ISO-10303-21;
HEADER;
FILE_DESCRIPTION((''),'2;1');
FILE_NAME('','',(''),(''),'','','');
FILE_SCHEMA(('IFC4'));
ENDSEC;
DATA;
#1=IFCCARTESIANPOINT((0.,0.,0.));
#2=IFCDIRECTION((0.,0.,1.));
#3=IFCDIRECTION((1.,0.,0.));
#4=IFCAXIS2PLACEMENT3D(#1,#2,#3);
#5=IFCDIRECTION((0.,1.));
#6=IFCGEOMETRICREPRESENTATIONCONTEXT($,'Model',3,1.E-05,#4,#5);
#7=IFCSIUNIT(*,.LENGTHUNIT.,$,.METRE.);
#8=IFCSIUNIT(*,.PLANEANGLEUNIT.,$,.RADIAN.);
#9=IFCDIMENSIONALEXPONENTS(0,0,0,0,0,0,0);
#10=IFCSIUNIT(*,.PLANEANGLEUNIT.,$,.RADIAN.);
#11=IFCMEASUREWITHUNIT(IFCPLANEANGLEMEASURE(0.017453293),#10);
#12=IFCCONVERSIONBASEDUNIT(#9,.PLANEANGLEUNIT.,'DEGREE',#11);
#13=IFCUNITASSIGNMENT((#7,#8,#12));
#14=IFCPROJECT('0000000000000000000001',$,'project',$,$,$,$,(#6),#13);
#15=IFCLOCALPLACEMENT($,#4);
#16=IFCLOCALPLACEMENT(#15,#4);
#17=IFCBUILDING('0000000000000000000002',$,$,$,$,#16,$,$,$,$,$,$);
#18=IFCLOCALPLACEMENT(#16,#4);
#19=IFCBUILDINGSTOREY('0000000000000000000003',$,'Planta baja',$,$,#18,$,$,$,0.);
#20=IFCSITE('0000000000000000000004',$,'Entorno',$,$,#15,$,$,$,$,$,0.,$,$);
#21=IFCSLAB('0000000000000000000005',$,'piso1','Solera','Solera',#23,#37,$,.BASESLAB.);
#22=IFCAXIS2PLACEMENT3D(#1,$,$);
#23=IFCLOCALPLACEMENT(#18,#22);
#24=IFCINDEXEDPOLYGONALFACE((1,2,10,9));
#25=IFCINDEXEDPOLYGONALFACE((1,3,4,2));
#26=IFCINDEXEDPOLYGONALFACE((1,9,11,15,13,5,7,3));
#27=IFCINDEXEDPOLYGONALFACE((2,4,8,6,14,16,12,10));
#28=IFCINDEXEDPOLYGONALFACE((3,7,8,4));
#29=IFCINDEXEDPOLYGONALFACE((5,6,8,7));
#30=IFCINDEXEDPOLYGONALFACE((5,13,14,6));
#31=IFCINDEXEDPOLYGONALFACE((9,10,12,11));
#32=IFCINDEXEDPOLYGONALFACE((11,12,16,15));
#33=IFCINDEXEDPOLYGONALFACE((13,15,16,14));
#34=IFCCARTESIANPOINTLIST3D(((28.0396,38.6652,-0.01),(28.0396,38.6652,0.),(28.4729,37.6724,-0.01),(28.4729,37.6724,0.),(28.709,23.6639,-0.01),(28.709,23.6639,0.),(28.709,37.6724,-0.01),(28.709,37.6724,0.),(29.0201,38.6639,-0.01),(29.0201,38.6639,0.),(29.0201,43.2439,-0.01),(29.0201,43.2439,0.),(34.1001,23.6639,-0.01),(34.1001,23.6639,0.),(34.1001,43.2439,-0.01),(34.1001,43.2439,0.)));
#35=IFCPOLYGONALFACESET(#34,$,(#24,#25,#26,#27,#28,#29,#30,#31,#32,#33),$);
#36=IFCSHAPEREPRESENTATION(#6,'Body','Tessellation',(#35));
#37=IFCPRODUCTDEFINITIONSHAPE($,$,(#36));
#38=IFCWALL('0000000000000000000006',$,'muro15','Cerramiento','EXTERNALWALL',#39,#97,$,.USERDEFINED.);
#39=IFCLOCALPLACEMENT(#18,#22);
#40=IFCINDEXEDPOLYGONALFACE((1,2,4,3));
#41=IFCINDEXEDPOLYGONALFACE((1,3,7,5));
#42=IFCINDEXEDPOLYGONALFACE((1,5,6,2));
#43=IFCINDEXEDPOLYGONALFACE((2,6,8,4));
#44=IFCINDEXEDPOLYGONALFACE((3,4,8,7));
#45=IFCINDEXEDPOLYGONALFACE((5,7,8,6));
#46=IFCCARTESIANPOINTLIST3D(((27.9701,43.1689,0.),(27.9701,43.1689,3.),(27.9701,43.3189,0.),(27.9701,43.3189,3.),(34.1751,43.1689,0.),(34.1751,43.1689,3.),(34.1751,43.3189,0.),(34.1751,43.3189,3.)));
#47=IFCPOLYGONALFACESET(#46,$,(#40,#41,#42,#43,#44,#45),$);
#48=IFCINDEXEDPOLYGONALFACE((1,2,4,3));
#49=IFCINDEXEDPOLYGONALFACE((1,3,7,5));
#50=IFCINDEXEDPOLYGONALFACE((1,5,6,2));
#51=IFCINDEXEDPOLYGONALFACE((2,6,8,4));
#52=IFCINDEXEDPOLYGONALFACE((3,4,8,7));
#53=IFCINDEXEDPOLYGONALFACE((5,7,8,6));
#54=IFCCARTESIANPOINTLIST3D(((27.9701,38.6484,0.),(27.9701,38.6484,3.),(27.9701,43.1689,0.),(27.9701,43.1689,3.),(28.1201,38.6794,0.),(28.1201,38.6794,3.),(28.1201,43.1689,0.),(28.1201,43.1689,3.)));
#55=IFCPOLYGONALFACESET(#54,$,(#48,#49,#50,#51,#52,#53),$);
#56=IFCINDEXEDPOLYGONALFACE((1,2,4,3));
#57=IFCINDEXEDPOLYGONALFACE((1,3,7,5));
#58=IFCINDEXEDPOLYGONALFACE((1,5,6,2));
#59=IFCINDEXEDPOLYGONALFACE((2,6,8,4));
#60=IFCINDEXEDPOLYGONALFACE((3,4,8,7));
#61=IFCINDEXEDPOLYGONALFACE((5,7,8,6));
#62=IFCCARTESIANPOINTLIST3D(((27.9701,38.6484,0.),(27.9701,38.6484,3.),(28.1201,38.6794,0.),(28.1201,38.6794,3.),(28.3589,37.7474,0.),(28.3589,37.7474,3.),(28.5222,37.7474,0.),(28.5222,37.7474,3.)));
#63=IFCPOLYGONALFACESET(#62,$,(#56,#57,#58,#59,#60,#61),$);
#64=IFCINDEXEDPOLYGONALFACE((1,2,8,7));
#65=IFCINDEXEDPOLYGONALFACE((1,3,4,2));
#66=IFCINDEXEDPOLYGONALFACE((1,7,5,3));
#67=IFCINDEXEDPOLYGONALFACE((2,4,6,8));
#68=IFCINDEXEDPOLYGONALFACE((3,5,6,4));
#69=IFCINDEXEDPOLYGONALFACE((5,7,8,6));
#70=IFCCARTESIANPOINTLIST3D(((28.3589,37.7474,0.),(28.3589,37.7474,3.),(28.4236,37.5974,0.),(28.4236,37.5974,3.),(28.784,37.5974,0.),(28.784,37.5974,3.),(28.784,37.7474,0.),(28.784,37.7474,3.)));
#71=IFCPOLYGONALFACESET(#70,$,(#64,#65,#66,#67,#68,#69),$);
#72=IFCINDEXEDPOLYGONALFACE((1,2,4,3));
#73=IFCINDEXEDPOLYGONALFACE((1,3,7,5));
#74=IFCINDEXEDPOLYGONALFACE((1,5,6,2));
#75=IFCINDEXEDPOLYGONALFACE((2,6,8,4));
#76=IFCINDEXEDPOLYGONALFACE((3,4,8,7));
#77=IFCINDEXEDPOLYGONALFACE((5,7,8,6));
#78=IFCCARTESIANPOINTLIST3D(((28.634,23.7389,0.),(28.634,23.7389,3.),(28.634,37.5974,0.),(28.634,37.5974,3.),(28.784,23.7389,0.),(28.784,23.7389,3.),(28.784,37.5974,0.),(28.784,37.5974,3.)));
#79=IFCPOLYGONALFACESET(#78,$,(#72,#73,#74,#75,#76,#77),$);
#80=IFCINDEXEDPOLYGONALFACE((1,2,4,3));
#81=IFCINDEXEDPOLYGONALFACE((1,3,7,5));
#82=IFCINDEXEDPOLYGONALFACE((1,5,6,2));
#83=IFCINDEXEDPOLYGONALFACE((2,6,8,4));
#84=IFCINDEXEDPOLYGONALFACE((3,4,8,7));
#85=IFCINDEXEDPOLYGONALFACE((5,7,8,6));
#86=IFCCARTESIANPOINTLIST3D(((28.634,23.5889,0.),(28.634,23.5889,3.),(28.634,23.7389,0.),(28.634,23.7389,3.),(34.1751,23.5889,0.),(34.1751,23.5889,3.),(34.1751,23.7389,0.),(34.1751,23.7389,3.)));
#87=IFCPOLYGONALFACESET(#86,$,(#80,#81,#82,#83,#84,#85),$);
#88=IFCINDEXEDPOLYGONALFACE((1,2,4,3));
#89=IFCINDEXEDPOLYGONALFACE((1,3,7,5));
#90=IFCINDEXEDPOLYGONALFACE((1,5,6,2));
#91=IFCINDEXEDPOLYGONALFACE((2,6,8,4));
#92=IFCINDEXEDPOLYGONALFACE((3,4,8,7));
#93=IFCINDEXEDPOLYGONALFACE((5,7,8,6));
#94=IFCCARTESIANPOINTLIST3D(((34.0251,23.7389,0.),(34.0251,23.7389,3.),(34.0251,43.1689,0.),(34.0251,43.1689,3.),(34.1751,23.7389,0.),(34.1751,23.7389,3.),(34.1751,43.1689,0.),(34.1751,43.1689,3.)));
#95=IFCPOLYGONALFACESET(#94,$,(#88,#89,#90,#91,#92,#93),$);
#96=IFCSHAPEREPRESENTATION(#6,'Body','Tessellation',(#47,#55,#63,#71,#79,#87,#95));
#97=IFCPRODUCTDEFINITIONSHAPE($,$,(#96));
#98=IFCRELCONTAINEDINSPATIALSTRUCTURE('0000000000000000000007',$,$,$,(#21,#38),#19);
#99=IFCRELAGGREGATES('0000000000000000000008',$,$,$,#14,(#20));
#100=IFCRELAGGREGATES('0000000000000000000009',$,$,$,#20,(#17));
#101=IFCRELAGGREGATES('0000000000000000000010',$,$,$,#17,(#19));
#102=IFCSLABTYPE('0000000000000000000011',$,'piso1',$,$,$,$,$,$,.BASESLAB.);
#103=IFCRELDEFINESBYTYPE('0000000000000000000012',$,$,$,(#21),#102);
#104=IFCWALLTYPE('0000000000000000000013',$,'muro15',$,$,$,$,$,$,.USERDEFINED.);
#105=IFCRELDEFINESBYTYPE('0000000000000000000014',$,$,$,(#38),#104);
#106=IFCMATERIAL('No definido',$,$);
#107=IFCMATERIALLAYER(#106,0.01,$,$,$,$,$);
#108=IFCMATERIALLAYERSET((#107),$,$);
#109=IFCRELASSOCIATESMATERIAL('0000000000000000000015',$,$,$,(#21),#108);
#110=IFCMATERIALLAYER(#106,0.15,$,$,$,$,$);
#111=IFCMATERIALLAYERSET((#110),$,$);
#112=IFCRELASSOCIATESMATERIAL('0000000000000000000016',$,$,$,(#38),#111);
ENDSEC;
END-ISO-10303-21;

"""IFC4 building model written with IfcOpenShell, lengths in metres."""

from ifc_helpers import new_model, entity, si_unit, converted_unit, direction, frame, origin_with_axes, place, context, project, spatial, polyline, outline, extrude, material, layer, layer_set, layer_usage, type_object, element, save


model = new_model("IFC4")

# Units and contexts
model_context = context("Model", 3, precision=1e-05, world=origin_with_axes(), true_north=direction((0.0, 1.0)))
ifc_project = project(units=[si_unit("LENGTHUNIT", "METRE"), si_unit("PLANEANGLEUNIT", "RADIAN"), converted_unit("PLANEANGLEUNIT", "DEGREE", entity("IfcPlaneAngleMeasure", 0.017453293), si_unit("PLANEANGLEUNIT", "RADIAN"), dimensions=[0, 0, 0, 0, 0, 0, 0])], contexts=[model_context])

# Site, building, storey
site_placement = place(None, origin_with_axes())
site = spatial("IfcSite", under=ifc_project, at=site_placement, Name="Entorno", RefElevation=0.0)
building_placement = place(site_placement, origin_with_axes())
building = spatial("IfcBuilding", under=site, at=building_placement)
storey_placement = place(building_placement, origin_with_axes())
storey = spatial("IfcBuildingStorey", under=building, at=storey_placement, Name="Planta baja", Elevation=0.0)

# Slab
ifc_material = material(Name="No definido")
ifc_layer_1 = layer(ifc_material, 0.01)
ifc_layer_set_1 = layer_set([ifc_layer_1])
ifc_layer_usage_1 = layer_usage(ifc_layer_set_1, "AXIS3", "POSITIVE", 0.0)
slab_type = type_object("IfcSlabType", Name="piso1", PredefinedType="BASESLAB")
slab_placement = place(storey_placement, frame((0.0, 0.0, -0.01), z_axis=(0.0, 0.0, 1.0), x_axis=(1.0, 0.0, 0.0)))
element("IfcSlab", 1, at=slab_placement, inside=storey, type_object=slab_type, material=ifc_layer_usage_1, Name="piso1", Description="Solera", ObjectType="Solera", PredefinedType="BASESLAB", context=model_context, shape_type="SweptSolid", body=[
    extrude(outline(polyline([(29.0201, 38.6639), (28.0396, 38.6652), (28.4729, 37.6724), (28.709, 37.6724), (28.709, 23.6639), (34.1001, 23.6639), (34.1001, 43.2439), (29.0201, 43.2439), (29.0201, 38.6639)])), origin_with_axes(), (0.0, 0.0, 1.0), 0.01),
])

# Wall
ifc_layer_2 = layer(ifc_material, 0.15)
ifc_layer_set_2 = layer_set([ifc_layer_2])
ifc_layer_usage_2 = layer_usage(ifc_layer_set_2, "AXIS2", "POSITIVE", -0.075)
wall_type = type_object("IfcWallType", Name="muro15", PredefinedType="USERDEFINED")
wall_placement = place(storey_placement, frame((34.1001, 43.2439, 0.0), z_axis=(0.0, 0.0, 1.0), x_axis=(-1.0, 0.0, 0.0)))
cartesian_point_1 = entity("IfcCartesianPoint", [-3.1025, -1.5])
cartesian_point_2 = entity("IfcCartesianPoint", [-3.1025, -1.5])
cartesian_point_3 = entity("IfcCartesianPoint", [-2.2448, -1.5])
cartesian_point_4 = entity("IfcCartesianPoint", [-2.2602, -1.5])
cartesian_point_5 = entity("IfcCartesianPoint", [-0.5075, -1.5])
cartesian_point_6 = entity("IfcCartesianPoint", [-0.4907, -1.5])
cartesian_point_7 = entity("IfcCartesianPoint", [-0.2126, -1.5])
cartesian_point_8 = entity("IfcCartesianPoint", [-0.1802, -1.5])
cartesian_point_9 = entity("IfcCartesianPoint", [-6.9292, -1.5])
cartesian_point_10 = entity("IfcCartesianPoint", [-6.9292, -1.5])
cartesian_point_11 = entity("IfcCartesianPoint", [-2.7706, -1.5])
cartesian_point_12 = entity("IfcCartesianPoint", [-2.7706, -1.5])
cartesian_point_13 = entity("IfcCartesianPoint", [-9.715, -1.5])
cartesian_point_14 = entity("IfcCartesianPoint", [-9.715, -1.5])
element("IfcWall", 2, at=wall_placement, inside=storey, type_object=wall_type, material=ifc_layer_usage_2, Name="muro15", Description="Cerramiento", ObjectType="EXTERNALWALL", PredefinedType="USERDEFINED", context=model_context, shape_type="SolidModel", body=[
    entity("IfcExtrudedAreaSolidTapered", entity("IfcArbitraryClosedProfileDef", "AREA", None, entity("IfcPolyline", [cartesian_point_1, entity("IfcCartesianPoint", [3.1025, -1.5]), entity("IfcCartesianPoint", [3.1025, 1.5]), entity("IfcCartesianPoint", [-3.1025, 1.5]), cartesian_point_1])), entity("IfcAxis2Placement3D", entity("IfcCartesianPoint", [3.0275, 0.075, 1.5]), entity("IfcDirection", [0.0, -1.0, 0.0]), entity("IfcDirection", [1.0, 0.0, 0.0])), entity("IfcDirection", [0.0, 0.0, 1.0]), 0.15, entity("IfcArbitraryClosedProfileDef", "AREA", None, entity("IfcPolyline", [cartesian_point_2, entity("IfcCartesianPoint", [3.1025, -1.5]), entity("IfcCartesianPoint", [3.1025, 1.5]), entity("IfcCartesianPoint", [-3.1025, 1.5]), cartesian_point_2]))),
    entity("IfcExtrudedAreaSolidTapered", entity("IfcArbitraryClosedProfileDef", "AREA", None, entity("IfcPolyline", [cartesian_point_3, entity("IfcCartesianPoint", [2.2448, -1.5]), entity("IfcCartesianPoint", [2.2448, 1.5]), entity("IfcCartesianPoint", [-2.2448, 1.5]), cartesian_point_3])), entity("IfcAxis2Placement3D", entity("IfcCartesianPoint", [5.98, 2.3197, 1.5]), entity("IfcDirection", [1.0, 0.0, 0.0]), entity("IfcDirection", [0.0, 1.0, 0.0])), entity("IfcDirection", [0.10272, 0.0, 0.99471]), 0.1508, entity("IfcArbitraryClosedProfileDef", "AREA", None, entity("IfcPolyline", [cartesian_point_4, entity("IfcCartesianPoint", [2.2602, -1.5]), entity("IfcCartesianPoint", [2.2602, 1.5]), entity("IfcCartesianPoint", [-2.2602, 1.5]), cartesian_point_4]))),
    entity("IfcExtrudedAreaSolidTapered", entity("IfcArbitraryClosedProfileDef", "AREA", None, entity("IfcPolyline", [cartesian_point_5, entity("IfcCartesianPoint", [0.5075, -1.5]), entity("IfcCartesianPoint", [0.5075, 1.5]), entity("IfcCartesianPoint", [-0.5075, 1.5]), cartesian_point_5])), entity("IfcAxis2Placement3D", entity("IfcCartesianPoint", [5.779, 5.0305, 1.5]), entity("IfcDirection", [0.91818, 0.396165, 0.0]), entity("IfcDirection", [-0.396165, 0.91818, 0.0])), entity("IfcDirection", [-0.303911, 0.0, 0.9527]), 0.1574, entity("IfcArbitraryClosedProfileDef", "AREA", None, entity("IfcPolyline", [cartesian_point_6, entity("IfcCartesianPoint", [0.4907, -1.5]), entity("IfcCartesianPoint", [0.4907, 1.5]), entity("IfcCartesianPoint", [-0.4907, 1.5]), cartesian_point_6]))),
    entity("IfcExtrudedAreaSolidTapered", entity("IfcArbitraryClosedProfileDef", "AREA", None, entity("IfcPolyline", [cartesian_point_7, entity("IfcCartesianPoint", [0.2126, -1.5]), entity("IfcCartesianPoint", [0.2126, 1.5]), entity("IfcCartesianPoint", [-0.2126, 1.5]), cartesian_point_7])), entity("IfcAxis2Placement3D", entity("IfcCartesianPoint", [5.5287, 5.4965, 1.5]), entity("IfcDirection", [0.0, 1.0, 0.0]), entity("IfcDirection", [-1.0, 0.0, 0.0])), entity("IfcDirection", [0.210882, 0.0, 0.977511]), 0.1535, entity("IfcArbitraryClosedProfileDef", "AREA", None, entity("IfcPolyline", [cartesian_point_8, entity("IfcCartesianPoint", [0.1802, -1.5]), entity("IfcCartesianPoint", [0.1802, 1.5]), entity("IfcCartesianPoint", [-0.1802, 1.5]), cartesian_point_8]))),
    entity("IfcExtrudedAreaSolidTapered", entity("IfcArbitraryClosedProfileDef", "AREA", None, entity("IfcPolyline", [cartesian_point_9, entity("IfcCartesianPoint", [6.9292, -1.5]), entity("IfcCartesianPoint", [6.9292, 1.5]), entity("IfcCartesianPoint", [-6.9292, 1.5]), cartesian_point_9])), entity("IfcAxis2Placement3D", entity("IfcCartesianPoint", [5.3161, 12.5757, 1.5]), entity("IfcDirection", [1.0, 0.0, 0.0]), entity("IfcDirection", [0.0, 1.0, 0.0])), entity("IfcDirection", [0.0, 0.0, 1.0]), 0.15, entity("IfcArbitraryClosedProfileDef", "AREA", None, entity("IfcPolyline", [cartesian_point_10, entity("IfcCartesianPoint", [6.9292, -1.5]), entity("IfcCartesianPoint", [6.9292, 1.5]), entity("IfcCartesianPoint", [-6.9292, 1.5]), cartesian_point_10]))),
    entity("IfcExtrudedAreaSolidTapered", entity("IfcArbitraryClosedProfileDef", "AREA", None, entity("IfcPolyline", [cartesian_point_11, entity("IfcCartesianPoint", [2.7706, -1.5]), entity("IfcCartesianPoint", [2.7706, 1.5]), entity("IfcCartesianPoint", [-2.7706, 1.5]), cartesian_point_11])), entity("IfcAxis2Placement3D", entity("IfcCartesianPoint", [2.6956, 19.505, 1.5]), entity("IfcDirection", [0.0, 1.0, 0.0]), entity("IfcDirection", [-1.0, 0.0, 0.0])), entity("IfcDirection", [0.0, 0.0, 1.0]), 0.15, entity("IfcArbitraryClosedProfileDef", "AREA", None, entity("IfcPolyline", [cartesian_point_12, entity("IfcCartesianPoint", [2.7706, -1.5]), entity("IfcCartesianPoint", [2.7706, 1.5]), entity("IfcCartesianPoint", [-2.7706, 1.5]), cartesian_point_12]))),
    entity("IfcExtrudedAreaSolidTapered", entity("IfcArbitraryClosedProfileDef", "AREA", None, entity("IfcPolyline", [cartesian_point_13, entity("IfcCartesianPoint", [9.715, -1.5]), entity("IfcCartesianPoint", [9.715, 1.5]), entity("IfcCartesianPoint", [-9.715, 1.5]), cartesian_point_13])), entity("IfcAxis2Placement3D", entity("IfcCartesianPoint", [0.075, 9.79, 1.5]), entity("IfcDirection", [-1.0, 0.0, 0.0]), entity("IfcDirection", [0.0, -1.0, 0.0])), entity("IfcDirection", [0.0, 0.0, 1.0]), 0.15, entity("IfcArbitraryClosedProfileDef", "AREA", None, entity("IfcPolyline", [cartesian_point_14, entity("IfcCartesianPoint", [9.715, -1.5]), entity("IfcCartesianPoint", [9.715, 1.5]), entity("IfcCartesianPoint", [-9.715, 1.5]), cartesian_point_14]))),
])

save(model, "model.ifc")
